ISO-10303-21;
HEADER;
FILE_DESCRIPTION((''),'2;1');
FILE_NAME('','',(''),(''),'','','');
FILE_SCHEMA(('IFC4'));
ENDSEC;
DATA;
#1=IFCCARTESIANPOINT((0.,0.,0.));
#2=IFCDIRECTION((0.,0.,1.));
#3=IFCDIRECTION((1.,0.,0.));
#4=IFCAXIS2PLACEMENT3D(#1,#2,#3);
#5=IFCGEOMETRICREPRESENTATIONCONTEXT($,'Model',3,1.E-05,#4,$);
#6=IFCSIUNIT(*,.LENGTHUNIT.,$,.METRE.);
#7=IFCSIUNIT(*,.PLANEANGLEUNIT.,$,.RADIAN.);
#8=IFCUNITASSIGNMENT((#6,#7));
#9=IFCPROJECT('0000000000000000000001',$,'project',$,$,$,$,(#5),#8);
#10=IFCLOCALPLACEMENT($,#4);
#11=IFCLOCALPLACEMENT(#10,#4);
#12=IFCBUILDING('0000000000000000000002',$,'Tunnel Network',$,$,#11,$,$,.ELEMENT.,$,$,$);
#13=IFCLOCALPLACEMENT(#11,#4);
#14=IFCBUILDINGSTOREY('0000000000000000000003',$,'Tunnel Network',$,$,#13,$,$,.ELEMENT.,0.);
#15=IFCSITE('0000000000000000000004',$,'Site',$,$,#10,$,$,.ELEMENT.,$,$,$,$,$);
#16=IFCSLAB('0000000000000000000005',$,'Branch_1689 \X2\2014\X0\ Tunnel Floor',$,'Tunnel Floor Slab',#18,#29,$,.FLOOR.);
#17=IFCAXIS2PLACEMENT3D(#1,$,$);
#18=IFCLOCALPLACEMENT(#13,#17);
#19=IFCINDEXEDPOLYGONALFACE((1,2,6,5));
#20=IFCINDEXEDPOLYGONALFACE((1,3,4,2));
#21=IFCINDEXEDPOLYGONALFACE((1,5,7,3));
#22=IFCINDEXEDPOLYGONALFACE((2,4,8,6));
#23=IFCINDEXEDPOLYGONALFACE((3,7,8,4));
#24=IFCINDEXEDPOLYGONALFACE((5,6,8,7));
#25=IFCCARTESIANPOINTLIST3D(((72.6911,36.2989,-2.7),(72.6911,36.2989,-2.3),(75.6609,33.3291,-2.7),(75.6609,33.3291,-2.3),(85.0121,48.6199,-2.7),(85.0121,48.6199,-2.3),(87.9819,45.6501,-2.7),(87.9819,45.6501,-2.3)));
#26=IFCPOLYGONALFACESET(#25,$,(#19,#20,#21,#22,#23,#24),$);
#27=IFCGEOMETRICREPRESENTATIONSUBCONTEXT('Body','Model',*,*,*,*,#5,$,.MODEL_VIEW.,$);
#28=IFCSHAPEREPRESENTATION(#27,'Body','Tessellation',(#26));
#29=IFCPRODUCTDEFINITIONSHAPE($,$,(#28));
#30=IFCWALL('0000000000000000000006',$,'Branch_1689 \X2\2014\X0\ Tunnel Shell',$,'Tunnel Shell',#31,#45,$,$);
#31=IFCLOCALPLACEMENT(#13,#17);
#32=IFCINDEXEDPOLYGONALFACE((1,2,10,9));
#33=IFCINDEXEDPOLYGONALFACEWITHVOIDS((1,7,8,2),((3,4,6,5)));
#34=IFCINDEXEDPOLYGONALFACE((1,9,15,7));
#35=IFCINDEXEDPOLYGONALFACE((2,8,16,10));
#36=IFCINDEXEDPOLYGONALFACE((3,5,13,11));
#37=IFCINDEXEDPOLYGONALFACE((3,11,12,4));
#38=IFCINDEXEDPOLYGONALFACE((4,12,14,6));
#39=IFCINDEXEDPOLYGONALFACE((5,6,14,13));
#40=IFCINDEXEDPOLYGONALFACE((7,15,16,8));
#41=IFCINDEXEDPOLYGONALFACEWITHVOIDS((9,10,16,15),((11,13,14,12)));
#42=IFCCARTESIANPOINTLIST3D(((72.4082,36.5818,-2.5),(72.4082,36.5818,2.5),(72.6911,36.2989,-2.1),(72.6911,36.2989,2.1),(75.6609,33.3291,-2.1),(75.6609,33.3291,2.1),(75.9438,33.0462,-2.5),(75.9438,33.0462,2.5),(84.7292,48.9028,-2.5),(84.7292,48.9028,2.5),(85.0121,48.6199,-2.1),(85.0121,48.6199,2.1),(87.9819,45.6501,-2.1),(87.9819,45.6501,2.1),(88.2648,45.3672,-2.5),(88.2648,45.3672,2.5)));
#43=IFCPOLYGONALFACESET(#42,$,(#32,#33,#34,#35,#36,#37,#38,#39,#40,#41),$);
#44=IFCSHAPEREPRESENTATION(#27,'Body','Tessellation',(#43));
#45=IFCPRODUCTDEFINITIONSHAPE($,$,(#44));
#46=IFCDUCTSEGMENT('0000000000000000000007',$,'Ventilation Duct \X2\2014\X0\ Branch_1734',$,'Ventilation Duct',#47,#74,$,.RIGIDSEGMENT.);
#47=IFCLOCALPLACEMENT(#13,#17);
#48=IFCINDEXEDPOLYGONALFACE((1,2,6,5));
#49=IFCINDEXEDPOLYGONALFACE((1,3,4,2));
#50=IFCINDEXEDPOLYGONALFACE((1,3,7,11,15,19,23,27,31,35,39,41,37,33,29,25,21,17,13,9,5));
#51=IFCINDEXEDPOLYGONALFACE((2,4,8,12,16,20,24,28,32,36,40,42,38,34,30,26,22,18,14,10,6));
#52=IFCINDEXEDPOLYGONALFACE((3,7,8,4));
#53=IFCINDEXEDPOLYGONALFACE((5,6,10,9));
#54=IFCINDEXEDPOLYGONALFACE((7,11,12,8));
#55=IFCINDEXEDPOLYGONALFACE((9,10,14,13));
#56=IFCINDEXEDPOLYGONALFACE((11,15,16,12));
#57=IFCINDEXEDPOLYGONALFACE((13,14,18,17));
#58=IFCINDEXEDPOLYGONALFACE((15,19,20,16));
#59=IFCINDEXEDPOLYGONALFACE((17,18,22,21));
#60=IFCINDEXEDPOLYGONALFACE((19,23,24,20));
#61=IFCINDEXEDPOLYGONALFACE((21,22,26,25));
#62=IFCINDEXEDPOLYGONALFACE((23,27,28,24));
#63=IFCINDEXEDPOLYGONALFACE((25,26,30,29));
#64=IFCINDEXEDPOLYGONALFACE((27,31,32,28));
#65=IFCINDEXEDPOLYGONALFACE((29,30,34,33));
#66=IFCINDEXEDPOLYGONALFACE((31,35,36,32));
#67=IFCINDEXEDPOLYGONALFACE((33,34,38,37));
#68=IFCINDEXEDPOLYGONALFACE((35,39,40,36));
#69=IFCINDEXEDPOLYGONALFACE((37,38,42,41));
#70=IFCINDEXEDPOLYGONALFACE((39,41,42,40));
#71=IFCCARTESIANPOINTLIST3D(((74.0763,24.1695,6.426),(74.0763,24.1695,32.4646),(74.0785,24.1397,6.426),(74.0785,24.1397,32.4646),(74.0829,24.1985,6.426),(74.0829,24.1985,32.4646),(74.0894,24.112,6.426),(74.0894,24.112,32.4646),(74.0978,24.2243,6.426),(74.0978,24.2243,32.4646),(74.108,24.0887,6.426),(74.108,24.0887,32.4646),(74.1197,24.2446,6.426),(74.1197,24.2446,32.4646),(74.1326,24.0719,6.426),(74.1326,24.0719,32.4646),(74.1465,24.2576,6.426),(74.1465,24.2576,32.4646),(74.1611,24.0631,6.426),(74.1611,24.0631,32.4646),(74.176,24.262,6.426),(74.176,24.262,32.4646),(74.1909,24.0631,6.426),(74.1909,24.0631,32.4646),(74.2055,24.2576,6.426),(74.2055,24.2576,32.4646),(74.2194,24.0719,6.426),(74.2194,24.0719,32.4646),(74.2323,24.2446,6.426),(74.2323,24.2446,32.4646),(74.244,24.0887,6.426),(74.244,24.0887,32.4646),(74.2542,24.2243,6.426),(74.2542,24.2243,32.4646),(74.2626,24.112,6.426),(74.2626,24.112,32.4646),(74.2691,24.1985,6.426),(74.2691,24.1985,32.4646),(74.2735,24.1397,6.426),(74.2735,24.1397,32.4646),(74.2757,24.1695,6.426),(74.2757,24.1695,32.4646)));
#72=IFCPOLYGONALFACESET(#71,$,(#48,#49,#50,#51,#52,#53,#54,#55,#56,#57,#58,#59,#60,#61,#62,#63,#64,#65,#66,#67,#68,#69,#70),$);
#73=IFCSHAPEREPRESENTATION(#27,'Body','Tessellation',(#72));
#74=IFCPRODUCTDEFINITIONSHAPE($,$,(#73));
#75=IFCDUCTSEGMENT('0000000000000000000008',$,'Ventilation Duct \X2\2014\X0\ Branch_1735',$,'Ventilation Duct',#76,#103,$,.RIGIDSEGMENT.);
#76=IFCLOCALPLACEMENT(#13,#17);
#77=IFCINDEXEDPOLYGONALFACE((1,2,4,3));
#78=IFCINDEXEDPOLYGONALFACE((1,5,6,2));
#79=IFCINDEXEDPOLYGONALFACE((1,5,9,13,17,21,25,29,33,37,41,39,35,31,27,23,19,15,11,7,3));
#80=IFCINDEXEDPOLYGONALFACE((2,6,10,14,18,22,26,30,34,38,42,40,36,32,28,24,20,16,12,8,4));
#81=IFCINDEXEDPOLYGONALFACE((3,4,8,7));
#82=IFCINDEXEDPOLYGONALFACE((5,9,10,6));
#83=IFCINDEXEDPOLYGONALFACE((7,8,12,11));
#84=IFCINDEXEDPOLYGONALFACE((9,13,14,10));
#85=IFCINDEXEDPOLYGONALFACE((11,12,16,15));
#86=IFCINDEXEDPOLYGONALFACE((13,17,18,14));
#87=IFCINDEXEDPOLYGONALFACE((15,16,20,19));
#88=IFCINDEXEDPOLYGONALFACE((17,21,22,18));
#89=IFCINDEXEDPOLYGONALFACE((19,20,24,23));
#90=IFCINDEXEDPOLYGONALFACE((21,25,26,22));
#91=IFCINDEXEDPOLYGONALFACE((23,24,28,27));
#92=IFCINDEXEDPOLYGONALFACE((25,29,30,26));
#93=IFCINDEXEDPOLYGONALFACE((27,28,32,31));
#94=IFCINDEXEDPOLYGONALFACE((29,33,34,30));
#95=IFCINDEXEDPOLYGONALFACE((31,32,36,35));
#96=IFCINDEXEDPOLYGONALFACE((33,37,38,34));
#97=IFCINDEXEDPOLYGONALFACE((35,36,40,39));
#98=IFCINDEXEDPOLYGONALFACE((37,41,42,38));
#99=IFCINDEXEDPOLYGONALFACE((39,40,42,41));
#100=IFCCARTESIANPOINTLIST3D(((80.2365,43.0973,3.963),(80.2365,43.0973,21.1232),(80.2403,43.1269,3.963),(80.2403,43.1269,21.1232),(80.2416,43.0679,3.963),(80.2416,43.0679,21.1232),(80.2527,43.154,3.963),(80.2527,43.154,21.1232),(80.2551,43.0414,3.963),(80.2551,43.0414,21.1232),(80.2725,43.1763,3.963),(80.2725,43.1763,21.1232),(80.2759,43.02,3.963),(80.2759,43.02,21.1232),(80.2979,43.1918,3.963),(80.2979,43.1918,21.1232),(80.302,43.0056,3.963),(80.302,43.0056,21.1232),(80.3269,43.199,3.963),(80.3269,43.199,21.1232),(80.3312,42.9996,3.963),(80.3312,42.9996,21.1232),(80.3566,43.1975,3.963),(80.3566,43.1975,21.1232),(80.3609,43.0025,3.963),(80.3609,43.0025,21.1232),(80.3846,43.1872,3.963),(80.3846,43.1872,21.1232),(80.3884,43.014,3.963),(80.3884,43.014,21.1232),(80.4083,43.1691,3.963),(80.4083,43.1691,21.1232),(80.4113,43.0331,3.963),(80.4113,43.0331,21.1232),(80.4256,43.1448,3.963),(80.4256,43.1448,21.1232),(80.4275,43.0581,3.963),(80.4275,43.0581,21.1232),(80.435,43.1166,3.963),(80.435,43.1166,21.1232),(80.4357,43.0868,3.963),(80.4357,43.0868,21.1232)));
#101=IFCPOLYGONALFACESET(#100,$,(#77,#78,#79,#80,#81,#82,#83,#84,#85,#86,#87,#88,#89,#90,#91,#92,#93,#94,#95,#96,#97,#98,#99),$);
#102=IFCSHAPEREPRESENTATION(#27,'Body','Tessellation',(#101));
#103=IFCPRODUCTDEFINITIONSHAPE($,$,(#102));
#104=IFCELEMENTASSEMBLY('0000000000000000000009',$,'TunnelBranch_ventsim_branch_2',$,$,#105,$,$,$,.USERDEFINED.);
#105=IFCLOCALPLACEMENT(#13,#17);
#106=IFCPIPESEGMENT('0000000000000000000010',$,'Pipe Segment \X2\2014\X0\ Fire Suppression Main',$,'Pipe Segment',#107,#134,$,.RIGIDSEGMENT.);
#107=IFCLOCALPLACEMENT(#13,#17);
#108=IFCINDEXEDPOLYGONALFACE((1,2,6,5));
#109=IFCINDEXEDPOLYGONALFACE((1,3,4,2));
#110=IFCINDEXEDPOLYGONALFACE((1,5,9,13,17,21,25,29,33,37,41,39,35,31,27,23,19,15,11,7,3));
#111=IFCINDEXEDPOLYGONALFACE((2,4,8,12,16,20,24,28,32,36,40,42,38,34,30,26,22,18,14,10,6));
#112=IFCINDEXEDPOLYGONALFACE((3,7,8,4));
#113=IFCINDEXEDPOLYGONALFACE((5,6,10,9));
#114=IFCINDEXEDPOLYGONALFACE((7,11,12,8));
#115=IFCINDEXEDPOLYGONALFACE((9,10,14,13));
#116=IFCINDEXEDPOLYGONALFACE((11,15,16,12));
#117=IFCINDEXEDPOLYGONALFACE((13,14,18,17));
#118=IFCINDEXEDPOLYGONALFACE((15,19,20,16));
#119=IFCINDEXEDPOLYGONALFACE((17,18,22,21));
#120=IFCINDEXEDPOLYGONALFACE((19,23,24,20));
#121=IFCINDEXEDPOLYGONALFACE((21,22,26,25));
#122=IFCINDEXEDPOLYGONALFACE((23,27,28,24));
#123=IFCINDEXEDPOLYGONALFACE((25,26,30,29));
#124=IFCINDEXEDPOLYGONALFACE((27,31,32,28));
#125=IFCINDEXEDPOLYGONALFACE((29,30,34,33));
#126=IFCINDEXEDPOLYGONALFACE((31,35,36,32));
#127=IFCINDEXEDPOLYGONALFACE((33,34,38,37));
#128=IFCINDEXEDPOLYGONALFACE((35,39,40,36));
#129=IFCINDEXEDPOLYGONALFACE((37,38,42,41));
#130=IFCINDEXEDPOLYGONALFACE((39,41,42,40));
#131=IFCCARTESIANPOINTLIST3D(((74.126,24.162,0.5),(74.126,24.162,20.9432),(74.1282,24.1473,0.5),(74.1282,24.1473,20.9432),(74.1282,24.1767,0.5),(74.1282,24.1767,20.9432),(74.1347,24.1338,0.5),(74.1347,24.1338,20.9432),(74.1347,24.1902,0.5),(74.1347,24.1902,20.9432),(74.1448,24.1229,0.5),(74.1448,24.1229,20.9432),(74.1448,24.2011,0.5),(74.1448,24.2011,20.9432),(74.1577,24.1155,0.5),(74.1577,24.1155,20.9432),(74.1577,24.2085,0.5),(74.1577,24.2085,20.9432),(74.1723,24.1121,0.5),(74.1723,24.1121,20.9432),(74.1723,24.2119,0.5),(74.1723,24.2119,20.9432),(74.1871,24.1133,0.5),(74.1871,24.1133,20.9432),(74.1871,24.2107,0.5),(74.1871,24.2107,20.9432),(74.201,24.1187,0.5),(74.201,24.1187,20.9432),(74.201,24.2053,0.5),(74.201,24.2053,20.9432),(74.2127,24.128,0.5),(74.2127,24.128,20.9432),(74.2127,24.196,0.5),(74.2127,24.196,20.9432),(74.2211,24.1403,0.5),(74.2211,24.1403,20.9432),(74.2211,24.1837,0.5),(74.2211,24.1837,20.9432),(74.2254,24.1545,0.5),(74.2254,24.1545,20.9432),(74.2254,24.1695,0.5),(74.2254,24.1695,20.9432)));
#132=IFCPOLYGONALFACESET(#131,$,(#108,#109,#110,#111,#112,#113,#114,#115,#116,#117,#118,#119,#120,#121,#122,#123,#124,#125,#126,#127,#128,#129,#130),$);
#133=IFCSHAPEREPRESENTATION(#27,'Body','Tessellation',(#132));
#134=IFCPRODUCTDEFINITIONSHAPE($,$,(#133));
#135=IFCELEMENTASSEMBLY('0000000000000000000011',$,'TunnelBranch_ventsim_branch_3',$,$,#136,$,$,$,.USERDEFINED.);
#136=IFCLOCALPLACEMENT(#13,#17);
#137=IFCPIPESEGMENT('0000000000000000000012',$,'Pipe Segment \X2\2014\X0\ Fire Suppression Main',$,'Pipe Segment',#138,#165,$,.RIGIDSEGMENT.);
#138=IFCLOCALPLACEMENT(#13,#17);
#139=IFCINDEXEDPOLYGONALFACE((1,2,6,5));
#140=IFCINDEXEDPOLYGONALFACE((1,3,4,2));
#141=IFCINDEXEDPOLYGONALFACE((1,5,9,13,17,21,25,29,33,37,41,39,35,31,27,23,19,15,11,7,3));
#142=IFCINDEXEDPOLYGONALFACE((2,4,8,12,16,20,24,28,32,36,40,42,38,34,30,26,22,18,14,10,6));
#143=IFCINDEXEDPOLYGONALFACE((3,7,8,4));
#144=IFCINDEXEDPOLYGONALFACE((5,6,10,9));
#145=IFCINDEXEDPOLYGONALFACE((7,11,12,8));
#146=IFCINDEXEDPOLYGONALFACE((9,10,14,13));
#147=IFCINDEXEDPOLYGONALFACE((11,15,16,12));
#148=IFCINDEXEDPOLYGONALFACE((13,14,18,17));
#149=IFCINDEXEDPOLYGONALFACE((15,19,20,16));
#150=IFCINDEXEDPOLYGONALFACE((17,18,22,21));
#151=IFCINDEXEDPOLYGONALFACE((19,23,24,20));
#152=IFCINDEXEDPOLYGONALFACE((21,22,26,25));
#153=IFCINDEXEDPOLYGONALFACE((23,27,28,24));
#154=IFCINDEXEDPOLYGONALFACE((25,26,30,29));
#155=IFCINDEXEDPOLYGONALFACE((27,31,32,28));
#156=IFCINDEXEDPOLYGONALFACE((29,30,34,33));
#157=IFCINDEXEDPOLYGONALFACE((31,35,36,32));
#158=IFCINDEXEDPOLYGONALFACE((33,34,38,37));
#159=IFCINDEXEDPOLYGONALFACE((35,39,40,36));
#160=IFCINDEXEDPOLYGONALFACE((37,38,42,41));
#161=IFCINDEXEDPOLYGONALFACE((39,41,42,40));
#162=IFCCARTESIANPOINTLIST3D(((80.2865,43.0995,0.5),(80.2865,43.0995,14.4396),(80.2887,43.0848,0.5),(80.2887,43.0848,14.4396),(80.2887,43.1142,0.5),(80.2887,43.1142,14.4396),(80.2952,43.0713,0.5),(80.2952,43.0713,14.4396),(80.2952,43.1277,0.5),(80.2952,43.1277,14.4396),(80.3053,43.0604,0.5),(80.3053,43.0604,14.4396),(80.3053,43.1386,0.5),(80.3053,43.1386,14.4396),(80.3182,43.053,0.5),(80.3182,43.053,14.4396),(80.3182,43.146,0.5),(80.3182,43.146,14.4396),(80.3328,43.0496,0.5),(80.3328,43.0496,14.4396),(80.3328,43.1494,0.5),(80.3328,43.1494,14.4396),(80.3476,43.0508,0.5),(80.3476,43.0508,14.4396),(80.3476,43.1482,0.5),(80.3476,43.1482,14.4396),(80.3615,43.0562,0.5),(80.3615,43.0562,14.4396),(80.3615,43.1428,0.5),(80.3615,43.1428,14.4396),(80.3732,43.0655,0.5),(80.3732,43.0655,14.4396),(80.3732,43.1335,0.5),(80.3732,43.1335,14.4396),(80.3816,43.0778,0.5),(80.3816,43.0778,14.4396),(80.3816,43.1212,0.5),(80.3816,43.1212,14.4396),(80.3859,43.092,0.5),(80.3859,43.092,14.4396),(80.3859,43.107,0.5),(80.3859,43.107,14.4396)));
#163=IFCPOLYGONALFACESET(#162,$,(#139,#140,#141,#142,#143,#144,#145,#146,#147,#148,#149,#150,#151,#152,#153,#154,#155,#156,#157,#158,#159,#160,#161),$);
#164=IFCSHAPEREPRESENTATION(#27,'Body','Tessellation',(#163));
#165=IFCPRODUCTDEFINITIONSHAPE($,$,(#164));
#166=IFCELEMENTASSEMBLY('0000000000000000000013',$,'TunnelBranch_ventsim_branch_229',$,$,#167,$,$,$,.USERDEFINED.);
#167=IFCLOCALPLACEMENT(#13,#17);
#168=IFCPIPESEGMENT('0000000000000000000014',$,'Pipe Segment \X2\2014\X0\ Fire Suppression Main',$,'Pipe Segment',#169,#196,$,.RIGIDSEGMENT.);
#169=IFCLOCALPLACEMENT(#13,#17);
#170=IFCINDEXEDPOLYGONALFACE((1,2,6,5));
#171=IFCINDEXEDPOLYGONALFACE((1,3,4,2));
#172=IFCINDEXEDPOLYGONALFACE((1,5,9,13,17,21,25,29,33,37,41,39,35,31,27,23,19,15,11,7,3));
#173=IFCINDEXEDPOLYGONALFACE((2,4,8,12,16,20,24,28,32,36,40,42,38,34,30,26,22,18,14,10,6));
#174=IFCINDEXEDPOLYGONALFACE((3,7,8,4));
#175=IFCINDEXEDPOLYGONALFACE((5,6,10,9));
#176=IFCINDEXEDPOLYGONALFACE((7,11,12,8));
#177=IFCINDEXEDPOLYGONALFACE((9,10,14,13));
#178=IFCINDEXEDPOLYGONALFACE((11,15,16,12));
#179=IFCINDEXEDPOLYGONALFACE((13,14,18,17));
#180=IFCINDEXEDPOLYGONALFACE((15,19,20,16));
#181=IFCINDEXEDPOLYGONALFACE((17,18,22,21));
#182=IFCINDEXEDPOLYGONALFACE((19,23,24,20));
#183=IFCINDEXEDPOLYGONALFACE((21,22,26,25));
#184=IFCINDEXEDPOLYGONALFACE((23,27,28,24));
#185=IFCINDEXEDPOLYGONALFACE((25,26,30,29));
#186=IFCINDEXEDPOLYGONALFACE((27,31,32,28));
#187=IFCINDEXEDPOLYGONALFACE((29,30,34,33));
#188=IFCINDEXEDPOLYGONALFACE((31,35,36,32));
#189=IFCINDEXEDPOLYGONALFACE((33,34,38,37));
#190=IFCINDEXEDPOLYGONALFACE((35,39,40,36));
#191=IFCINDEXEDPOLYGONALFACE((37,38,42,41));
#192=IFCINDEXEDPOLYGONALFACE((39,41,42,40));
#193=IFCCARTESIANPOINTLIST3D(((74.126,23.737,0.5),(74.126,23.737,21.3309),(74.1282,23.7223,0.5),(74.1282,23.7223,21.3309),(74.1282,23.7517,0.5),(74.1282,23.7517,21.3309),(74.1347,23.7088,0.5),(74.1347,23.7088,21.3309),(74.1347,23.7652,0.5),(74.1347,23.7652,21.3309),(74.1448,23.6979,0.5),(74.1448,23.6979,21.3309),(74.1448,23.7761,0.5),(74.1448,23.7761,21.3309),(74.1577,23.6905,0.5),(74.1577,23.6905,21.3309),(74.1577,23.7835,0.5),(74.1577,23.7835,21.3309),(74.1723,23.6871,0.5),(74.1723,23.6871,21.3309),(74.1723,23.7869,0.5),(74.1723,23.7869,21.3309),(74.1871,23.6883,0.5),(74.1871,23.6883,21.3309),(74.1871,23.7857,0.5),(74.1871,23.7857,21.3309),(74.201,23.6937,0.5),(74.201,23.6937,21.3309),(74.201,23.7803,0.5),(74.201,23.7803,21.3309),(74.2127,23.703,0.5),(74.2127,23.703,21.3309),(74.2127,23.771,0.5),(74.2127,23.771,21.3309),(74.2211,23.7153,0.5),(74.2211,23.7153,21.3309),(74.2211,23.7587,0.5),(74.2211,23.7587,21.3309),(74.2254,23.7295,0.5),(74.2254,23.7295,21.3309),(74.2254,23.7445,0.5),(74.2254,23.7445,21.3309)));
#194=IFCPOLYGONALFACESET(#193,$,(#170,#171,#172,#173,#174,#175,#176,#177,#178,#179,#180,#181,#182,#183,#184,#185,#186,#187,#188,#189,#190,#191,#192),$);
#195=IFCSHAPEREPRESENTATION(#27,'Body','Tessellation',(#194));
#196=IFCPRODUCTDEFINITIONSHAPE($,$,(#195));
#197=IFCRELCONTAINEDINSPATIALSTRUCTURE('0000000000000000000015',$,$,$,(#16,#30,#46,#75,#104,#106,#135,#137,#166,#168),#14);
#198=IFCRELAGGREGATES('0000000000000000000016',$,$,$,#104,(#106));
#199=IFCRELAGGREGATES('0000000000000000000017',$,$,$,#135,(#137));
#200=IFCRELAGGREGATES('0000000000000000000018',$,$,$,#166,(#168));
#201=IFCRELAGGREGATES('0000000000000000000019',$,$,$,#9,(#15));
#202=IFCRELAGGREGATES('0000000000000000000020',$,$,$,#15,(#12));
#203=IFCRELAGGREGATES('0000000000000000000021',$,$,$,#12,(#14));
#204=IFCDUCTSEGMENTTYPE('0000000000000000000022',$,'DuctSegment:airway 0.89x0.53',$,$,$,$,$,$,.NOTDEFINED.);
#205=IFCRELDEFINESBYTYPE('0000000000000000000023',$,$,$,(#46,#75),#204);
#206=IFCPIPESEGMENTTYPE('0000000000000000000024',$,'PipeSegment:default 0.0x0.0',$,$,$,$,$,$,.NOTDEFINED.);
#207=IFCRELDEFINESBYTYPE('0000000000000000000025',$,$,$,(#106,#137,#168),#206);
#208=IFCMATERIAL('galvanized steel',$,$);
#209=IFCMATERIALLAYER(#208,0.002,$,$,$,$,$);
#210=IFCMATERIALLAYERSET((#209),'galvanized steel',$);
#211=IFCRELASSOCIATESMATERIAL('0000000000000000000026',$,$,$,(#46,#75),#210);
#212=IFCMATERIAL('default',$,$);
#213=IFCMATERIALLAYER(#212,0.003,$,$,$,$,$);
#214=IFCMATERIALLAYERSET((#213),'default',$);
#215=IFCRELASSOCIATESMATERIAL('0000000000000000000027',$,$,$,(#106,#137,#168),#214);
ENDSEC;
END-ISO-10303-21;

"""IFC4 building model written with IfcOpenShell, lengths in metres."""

from ifc_helpers import new_model, entity, si_unit, frame, origin_with_axes, origin_2d_with_axis, place, context, subcontext, project, spatial, rectangle, hollow_rectangle, circle, extrude, material, layer, layer_set, layer_usage, type_object, element, aggregate, save


model = new_model("IFC4")

# Units and contexts
model_context = context("Model", 3, precision=1e-05, world=origin_with_axes())
body_context = subcontext(model_context, "Body", "Model", "MODEL_VIEW")
ifc_project = project(units=[si_unit("LENGTHUNIT", "METRE"), si_unit("PLANEANGLEUNIT", "RADIAN")], contexts=[model_context])

# Site, building, storey
site_placement = place(None, origin_with_axes())
site = spatial("IfcSite", under=ifc_project, at=site_placement, Name="Site", CompositionType="ELEMENT")
building_placement = place(site_placement, origin_with_axes())
building = spatial("IfcBuilding", under=site, at=building_placement, Name="Tunnel Network", CompositionType="ELEMENT")
storey_placement = place(building_placement, origin_with_axes())
storey = spatial("IfcBuildingStorey", under=building, at=storey_placement, Name="Tunnel Network", CompositionType="ELEMENT", Elevation=0.0)

# Slab
placement = place(storey_placement, frame((74.176, 34.814, 0.0), z_axis=(0.0, 0.0, 1.0), x_axis=(0.707107, 0.707107, 0.0)))
element("IfcSlab", 1, at=placement, inside=storey, Name="Branch_1689 — Tunnel Floor", ObjectType="Tunnel Floor Slab", PredefinedType="FLOOR", context=body_context, shape_type="SweptSolid", body=[
    extrude(rectangle(XDim=0.4, YDim=4.2, at=origin_2d_with_axis()), frame((0.0, 0.0, -2.5), z_axis=(1.0, 0.0, 0.0), x_axis=(0.0, 0.0, 1.0)), (0.0, 0.0, 1.0), 17.4245),
])

# Wall
element("IfcWall", 2, at=placement, inside=storey, Name="Branch_1689 — Tunnel Shell", ObjectType="Tunnel Shell", context=body_context, shape_type="SweptSolid", body=[
    extrude(hollow_rectangle(XDim=5.0, YDim=5.0, WallThickness=0.4, at=origin_2d_with_axis()), frame((0.0, 0.0, 0.0), z_axis=(1.0, 0.0, 0.0), x_axis=(0.0, 0.0, 1.0)), (0.0, 0.0, 1.0), 17.4245),
])

# Duct segments
ifc_material_1 = material(Name="galvanized steel")
ifc_layer_1 = layer(ifc_material_1, 0.002)
ifc_layer_set_1 = layer_set([ifc_layer_1], Name="galvanized steel")
ifc_layer_usage_1 = layer_usage(ifc_layer_set_1, "AXIS2", "POSITIVE", 0.0)
duct_segment_type = type_object("IfcDuctSegmentType", Name="DuctSegment:airway 0.89x0.53")
duct_segment_1_placement = place(storey_placement, frame((74.176, 24.162, 6.426), z_axis=(0.0, 0.0, 1.0), x_axis=(0.0, 1.0, 0.0)))
element("IfcDuctSegment", 3, at=duct_segment_1_placement, inside=storey, type_object=duct_segment_type, material=ifc_layer_usage_1, Name="Ventilation Duct — Branch_1734", ObjectType="Ventilation Duct", PredefinedType="RIGIDSEGMENT", context=body_context, shape_type="AdvancedSweptSolid", body=[
    entity("IfcSweptDiskSolid", entity("IfcPolyline", [entity("IfcCartesianPoint", [0.0, 0.0, 0.0]), entity("IfcCartesianPoint", [0.0, 0.0, 26.0386])]), 0.1),
])
ifc_layer_usage_2 = layer_usage(ifc_layer_set_1, "AXIS2", "POSITIVE", 0.0)
duct_segment_2_placement = place(storey_placement, frame((80.3365, 43.0995, 3.963), z_axis=(0.0, 0.0, 1.0), x_axis=(0.718006, 0.696037, 0.0)))
element("IfcDuctSegment", 4, at=duct_segment_2_placement, inside=storey, type_object=duct_segment_type, material=ifc_layer_usage_2, Name="Ventilation Duct — Branch_1735", ObjectType="Ventilation Duct", PredefinedType="RIGIDSEGMENT", context=body_context, shape_type="AdvancedSweptSolid", body=[
    entity("IfcSweptDiskSolid", entity("IfcPolyline", [entity("IfcCartesianPoint", [0.0, 0.0, 0.0]), entity("IfcCartesianPoint", [0.0, 0.0, 17.1602])]), 0.1),
])

# Element assemblies, pipe segments
assembly_1_placement = place(storey_placement, frame((74.176, 24.162, 1.25), z_axis=(0.0, 1.0, 0.0), x_axis=(-1.0, 0.0, 0.0)))
assembly_1 = element("IfcElementAssembly", 5, at=assembly_1_placement, inside=storey, Name="TunnelBranch_ventsim_branch_2", PredefinedType="USERDEFINED")
ifc_material_2 = material(Name="default")
ifc_layer_2 = layer(ifc_material_2, 0.003)
ifc_layer_set_2 = layer_set([ifc_layer_2], Name="default")
ifc_layer_usage_3 = layer_usage(ifc_layer_set_2, "AXIS2", "POSITIVE", 0.0)
pipe_segment_type = type_object("IfcPipeSegmentType", Name="PipeSegment:default 0.0x0.0")
pipe_segment_1_placement = place(storey_placement, frame((74.176, 24.162, 0.5), z_axis=(0.0, 0.0, 1.0), x_axis=(-1.0, 0.0, 0.0)))
pipe_segment_1 = element("IfcPipeSegment", 6, at=pipe_segment_1_placement, inside=storey, type_object=pipe_segment_type, material=ifc_layer_usage_3, Name="Pipe Segment — Fire Suppression Main", ObjectType="Pipe Segment", PredefinedType="RIGIDSEGMENT", context=body_context, shape_type="SweptSolid", body=[
    extrude(circle(Radius=0.05, at=origin_2d_with_axis()), origin_with_axes(), (0.0, 0.0, 1.0), 20.4432),
])
assembly_2_placement = place(storey_placement, frame((80.3365, 43.0995, 0.5), z_axis=(0.0, 0.0, 1.0), x_axis=(-1.0, 0.0, 0.0)))
assembly_2 = element("IfcElementAssembly", 7, at=assembly_2_placement, inside=storey, Name="TunnelBranch_ventsim_branch_3", PredefinedType="USERDEFINED")
ifc_layer_usage_4 = layer_usage(ifc_layer_set_2, "AXIS2", "POSITIVE", 0.0)
pipe_segment_2_placement = place(storey_placement, frame((80.3365, 43.0995, 0.5), z_axis=(0.0, 0.0, 1.0), x_axis=(-1.0, 0.0, 0.0)))
pipe_segment_2 = element("IfcPipeSegment", 8, at=pipe_segment_2_placement, inside=storey, type_object=pipe_segment_type, material=ifc_layer_usage_4, Name="Pipe Segment — Fire Suppression Main", ObjectType="Pipe Segment", PredefinedType="RIGIDSEGMENT", context=body_context, shape_type="SweptSolid", body=[
    extrude(circle(Radius=0.05, at=origin_2d_with_axis()), origin_with_axes(), (0.0, 0.0, 1.0), 13.9396),
])
assembly_3_placement = place(storey_placement, frame((74.176, 23.737, 1.25), z_axis=(0.0, 1.0, 0.0), x_axis=(-1.0, 0.0, 0.0)))
assembly_3 = element("IfcElementAssembly", 9, at=assembly_3_placement, inside=storey, Name="TunnelBranch_ventsim_branch_229", PredefinedType="USERDEFINED")
ifc_layer_usage_5 = layer_usage(ifc_layer_set_2, "AXIS2", "POSITIVE", 0.0)
pipe_segment_3_placement = place(storey_placement, frame((74.176, 23.737, 0.5), z_axis=(0.0, 0.0, 1.0), x_axis=(-1.0, 0.0, 0.0)))
pipe_segment_3 = element("IfcPipeSegment", 10, at=pipe_segment_3_placement, inside=storey, type_object=pipe_segment_type, material=ifc_layer_usage_5, Name="Pipe Segment — Fire Suppression Main", ObjectType="Pipe Segment", PredefinedType="RIGIDSEGMENT", context=body_context, shape_type="SweptSolid", body=[
    extrude(circle(Radius=0.05, at=origin_2d_with_axis()), origin_with_axes(), (0.0, 0.0, 1.0), 20.8309),
])

aggregate(assembly_1, [pipe_segment_1])

aggregate(assembly_2, [pipe_segment_2])

aggregate(assembly_3, [pipe_segment_3])

save(model, "model.ifc")
